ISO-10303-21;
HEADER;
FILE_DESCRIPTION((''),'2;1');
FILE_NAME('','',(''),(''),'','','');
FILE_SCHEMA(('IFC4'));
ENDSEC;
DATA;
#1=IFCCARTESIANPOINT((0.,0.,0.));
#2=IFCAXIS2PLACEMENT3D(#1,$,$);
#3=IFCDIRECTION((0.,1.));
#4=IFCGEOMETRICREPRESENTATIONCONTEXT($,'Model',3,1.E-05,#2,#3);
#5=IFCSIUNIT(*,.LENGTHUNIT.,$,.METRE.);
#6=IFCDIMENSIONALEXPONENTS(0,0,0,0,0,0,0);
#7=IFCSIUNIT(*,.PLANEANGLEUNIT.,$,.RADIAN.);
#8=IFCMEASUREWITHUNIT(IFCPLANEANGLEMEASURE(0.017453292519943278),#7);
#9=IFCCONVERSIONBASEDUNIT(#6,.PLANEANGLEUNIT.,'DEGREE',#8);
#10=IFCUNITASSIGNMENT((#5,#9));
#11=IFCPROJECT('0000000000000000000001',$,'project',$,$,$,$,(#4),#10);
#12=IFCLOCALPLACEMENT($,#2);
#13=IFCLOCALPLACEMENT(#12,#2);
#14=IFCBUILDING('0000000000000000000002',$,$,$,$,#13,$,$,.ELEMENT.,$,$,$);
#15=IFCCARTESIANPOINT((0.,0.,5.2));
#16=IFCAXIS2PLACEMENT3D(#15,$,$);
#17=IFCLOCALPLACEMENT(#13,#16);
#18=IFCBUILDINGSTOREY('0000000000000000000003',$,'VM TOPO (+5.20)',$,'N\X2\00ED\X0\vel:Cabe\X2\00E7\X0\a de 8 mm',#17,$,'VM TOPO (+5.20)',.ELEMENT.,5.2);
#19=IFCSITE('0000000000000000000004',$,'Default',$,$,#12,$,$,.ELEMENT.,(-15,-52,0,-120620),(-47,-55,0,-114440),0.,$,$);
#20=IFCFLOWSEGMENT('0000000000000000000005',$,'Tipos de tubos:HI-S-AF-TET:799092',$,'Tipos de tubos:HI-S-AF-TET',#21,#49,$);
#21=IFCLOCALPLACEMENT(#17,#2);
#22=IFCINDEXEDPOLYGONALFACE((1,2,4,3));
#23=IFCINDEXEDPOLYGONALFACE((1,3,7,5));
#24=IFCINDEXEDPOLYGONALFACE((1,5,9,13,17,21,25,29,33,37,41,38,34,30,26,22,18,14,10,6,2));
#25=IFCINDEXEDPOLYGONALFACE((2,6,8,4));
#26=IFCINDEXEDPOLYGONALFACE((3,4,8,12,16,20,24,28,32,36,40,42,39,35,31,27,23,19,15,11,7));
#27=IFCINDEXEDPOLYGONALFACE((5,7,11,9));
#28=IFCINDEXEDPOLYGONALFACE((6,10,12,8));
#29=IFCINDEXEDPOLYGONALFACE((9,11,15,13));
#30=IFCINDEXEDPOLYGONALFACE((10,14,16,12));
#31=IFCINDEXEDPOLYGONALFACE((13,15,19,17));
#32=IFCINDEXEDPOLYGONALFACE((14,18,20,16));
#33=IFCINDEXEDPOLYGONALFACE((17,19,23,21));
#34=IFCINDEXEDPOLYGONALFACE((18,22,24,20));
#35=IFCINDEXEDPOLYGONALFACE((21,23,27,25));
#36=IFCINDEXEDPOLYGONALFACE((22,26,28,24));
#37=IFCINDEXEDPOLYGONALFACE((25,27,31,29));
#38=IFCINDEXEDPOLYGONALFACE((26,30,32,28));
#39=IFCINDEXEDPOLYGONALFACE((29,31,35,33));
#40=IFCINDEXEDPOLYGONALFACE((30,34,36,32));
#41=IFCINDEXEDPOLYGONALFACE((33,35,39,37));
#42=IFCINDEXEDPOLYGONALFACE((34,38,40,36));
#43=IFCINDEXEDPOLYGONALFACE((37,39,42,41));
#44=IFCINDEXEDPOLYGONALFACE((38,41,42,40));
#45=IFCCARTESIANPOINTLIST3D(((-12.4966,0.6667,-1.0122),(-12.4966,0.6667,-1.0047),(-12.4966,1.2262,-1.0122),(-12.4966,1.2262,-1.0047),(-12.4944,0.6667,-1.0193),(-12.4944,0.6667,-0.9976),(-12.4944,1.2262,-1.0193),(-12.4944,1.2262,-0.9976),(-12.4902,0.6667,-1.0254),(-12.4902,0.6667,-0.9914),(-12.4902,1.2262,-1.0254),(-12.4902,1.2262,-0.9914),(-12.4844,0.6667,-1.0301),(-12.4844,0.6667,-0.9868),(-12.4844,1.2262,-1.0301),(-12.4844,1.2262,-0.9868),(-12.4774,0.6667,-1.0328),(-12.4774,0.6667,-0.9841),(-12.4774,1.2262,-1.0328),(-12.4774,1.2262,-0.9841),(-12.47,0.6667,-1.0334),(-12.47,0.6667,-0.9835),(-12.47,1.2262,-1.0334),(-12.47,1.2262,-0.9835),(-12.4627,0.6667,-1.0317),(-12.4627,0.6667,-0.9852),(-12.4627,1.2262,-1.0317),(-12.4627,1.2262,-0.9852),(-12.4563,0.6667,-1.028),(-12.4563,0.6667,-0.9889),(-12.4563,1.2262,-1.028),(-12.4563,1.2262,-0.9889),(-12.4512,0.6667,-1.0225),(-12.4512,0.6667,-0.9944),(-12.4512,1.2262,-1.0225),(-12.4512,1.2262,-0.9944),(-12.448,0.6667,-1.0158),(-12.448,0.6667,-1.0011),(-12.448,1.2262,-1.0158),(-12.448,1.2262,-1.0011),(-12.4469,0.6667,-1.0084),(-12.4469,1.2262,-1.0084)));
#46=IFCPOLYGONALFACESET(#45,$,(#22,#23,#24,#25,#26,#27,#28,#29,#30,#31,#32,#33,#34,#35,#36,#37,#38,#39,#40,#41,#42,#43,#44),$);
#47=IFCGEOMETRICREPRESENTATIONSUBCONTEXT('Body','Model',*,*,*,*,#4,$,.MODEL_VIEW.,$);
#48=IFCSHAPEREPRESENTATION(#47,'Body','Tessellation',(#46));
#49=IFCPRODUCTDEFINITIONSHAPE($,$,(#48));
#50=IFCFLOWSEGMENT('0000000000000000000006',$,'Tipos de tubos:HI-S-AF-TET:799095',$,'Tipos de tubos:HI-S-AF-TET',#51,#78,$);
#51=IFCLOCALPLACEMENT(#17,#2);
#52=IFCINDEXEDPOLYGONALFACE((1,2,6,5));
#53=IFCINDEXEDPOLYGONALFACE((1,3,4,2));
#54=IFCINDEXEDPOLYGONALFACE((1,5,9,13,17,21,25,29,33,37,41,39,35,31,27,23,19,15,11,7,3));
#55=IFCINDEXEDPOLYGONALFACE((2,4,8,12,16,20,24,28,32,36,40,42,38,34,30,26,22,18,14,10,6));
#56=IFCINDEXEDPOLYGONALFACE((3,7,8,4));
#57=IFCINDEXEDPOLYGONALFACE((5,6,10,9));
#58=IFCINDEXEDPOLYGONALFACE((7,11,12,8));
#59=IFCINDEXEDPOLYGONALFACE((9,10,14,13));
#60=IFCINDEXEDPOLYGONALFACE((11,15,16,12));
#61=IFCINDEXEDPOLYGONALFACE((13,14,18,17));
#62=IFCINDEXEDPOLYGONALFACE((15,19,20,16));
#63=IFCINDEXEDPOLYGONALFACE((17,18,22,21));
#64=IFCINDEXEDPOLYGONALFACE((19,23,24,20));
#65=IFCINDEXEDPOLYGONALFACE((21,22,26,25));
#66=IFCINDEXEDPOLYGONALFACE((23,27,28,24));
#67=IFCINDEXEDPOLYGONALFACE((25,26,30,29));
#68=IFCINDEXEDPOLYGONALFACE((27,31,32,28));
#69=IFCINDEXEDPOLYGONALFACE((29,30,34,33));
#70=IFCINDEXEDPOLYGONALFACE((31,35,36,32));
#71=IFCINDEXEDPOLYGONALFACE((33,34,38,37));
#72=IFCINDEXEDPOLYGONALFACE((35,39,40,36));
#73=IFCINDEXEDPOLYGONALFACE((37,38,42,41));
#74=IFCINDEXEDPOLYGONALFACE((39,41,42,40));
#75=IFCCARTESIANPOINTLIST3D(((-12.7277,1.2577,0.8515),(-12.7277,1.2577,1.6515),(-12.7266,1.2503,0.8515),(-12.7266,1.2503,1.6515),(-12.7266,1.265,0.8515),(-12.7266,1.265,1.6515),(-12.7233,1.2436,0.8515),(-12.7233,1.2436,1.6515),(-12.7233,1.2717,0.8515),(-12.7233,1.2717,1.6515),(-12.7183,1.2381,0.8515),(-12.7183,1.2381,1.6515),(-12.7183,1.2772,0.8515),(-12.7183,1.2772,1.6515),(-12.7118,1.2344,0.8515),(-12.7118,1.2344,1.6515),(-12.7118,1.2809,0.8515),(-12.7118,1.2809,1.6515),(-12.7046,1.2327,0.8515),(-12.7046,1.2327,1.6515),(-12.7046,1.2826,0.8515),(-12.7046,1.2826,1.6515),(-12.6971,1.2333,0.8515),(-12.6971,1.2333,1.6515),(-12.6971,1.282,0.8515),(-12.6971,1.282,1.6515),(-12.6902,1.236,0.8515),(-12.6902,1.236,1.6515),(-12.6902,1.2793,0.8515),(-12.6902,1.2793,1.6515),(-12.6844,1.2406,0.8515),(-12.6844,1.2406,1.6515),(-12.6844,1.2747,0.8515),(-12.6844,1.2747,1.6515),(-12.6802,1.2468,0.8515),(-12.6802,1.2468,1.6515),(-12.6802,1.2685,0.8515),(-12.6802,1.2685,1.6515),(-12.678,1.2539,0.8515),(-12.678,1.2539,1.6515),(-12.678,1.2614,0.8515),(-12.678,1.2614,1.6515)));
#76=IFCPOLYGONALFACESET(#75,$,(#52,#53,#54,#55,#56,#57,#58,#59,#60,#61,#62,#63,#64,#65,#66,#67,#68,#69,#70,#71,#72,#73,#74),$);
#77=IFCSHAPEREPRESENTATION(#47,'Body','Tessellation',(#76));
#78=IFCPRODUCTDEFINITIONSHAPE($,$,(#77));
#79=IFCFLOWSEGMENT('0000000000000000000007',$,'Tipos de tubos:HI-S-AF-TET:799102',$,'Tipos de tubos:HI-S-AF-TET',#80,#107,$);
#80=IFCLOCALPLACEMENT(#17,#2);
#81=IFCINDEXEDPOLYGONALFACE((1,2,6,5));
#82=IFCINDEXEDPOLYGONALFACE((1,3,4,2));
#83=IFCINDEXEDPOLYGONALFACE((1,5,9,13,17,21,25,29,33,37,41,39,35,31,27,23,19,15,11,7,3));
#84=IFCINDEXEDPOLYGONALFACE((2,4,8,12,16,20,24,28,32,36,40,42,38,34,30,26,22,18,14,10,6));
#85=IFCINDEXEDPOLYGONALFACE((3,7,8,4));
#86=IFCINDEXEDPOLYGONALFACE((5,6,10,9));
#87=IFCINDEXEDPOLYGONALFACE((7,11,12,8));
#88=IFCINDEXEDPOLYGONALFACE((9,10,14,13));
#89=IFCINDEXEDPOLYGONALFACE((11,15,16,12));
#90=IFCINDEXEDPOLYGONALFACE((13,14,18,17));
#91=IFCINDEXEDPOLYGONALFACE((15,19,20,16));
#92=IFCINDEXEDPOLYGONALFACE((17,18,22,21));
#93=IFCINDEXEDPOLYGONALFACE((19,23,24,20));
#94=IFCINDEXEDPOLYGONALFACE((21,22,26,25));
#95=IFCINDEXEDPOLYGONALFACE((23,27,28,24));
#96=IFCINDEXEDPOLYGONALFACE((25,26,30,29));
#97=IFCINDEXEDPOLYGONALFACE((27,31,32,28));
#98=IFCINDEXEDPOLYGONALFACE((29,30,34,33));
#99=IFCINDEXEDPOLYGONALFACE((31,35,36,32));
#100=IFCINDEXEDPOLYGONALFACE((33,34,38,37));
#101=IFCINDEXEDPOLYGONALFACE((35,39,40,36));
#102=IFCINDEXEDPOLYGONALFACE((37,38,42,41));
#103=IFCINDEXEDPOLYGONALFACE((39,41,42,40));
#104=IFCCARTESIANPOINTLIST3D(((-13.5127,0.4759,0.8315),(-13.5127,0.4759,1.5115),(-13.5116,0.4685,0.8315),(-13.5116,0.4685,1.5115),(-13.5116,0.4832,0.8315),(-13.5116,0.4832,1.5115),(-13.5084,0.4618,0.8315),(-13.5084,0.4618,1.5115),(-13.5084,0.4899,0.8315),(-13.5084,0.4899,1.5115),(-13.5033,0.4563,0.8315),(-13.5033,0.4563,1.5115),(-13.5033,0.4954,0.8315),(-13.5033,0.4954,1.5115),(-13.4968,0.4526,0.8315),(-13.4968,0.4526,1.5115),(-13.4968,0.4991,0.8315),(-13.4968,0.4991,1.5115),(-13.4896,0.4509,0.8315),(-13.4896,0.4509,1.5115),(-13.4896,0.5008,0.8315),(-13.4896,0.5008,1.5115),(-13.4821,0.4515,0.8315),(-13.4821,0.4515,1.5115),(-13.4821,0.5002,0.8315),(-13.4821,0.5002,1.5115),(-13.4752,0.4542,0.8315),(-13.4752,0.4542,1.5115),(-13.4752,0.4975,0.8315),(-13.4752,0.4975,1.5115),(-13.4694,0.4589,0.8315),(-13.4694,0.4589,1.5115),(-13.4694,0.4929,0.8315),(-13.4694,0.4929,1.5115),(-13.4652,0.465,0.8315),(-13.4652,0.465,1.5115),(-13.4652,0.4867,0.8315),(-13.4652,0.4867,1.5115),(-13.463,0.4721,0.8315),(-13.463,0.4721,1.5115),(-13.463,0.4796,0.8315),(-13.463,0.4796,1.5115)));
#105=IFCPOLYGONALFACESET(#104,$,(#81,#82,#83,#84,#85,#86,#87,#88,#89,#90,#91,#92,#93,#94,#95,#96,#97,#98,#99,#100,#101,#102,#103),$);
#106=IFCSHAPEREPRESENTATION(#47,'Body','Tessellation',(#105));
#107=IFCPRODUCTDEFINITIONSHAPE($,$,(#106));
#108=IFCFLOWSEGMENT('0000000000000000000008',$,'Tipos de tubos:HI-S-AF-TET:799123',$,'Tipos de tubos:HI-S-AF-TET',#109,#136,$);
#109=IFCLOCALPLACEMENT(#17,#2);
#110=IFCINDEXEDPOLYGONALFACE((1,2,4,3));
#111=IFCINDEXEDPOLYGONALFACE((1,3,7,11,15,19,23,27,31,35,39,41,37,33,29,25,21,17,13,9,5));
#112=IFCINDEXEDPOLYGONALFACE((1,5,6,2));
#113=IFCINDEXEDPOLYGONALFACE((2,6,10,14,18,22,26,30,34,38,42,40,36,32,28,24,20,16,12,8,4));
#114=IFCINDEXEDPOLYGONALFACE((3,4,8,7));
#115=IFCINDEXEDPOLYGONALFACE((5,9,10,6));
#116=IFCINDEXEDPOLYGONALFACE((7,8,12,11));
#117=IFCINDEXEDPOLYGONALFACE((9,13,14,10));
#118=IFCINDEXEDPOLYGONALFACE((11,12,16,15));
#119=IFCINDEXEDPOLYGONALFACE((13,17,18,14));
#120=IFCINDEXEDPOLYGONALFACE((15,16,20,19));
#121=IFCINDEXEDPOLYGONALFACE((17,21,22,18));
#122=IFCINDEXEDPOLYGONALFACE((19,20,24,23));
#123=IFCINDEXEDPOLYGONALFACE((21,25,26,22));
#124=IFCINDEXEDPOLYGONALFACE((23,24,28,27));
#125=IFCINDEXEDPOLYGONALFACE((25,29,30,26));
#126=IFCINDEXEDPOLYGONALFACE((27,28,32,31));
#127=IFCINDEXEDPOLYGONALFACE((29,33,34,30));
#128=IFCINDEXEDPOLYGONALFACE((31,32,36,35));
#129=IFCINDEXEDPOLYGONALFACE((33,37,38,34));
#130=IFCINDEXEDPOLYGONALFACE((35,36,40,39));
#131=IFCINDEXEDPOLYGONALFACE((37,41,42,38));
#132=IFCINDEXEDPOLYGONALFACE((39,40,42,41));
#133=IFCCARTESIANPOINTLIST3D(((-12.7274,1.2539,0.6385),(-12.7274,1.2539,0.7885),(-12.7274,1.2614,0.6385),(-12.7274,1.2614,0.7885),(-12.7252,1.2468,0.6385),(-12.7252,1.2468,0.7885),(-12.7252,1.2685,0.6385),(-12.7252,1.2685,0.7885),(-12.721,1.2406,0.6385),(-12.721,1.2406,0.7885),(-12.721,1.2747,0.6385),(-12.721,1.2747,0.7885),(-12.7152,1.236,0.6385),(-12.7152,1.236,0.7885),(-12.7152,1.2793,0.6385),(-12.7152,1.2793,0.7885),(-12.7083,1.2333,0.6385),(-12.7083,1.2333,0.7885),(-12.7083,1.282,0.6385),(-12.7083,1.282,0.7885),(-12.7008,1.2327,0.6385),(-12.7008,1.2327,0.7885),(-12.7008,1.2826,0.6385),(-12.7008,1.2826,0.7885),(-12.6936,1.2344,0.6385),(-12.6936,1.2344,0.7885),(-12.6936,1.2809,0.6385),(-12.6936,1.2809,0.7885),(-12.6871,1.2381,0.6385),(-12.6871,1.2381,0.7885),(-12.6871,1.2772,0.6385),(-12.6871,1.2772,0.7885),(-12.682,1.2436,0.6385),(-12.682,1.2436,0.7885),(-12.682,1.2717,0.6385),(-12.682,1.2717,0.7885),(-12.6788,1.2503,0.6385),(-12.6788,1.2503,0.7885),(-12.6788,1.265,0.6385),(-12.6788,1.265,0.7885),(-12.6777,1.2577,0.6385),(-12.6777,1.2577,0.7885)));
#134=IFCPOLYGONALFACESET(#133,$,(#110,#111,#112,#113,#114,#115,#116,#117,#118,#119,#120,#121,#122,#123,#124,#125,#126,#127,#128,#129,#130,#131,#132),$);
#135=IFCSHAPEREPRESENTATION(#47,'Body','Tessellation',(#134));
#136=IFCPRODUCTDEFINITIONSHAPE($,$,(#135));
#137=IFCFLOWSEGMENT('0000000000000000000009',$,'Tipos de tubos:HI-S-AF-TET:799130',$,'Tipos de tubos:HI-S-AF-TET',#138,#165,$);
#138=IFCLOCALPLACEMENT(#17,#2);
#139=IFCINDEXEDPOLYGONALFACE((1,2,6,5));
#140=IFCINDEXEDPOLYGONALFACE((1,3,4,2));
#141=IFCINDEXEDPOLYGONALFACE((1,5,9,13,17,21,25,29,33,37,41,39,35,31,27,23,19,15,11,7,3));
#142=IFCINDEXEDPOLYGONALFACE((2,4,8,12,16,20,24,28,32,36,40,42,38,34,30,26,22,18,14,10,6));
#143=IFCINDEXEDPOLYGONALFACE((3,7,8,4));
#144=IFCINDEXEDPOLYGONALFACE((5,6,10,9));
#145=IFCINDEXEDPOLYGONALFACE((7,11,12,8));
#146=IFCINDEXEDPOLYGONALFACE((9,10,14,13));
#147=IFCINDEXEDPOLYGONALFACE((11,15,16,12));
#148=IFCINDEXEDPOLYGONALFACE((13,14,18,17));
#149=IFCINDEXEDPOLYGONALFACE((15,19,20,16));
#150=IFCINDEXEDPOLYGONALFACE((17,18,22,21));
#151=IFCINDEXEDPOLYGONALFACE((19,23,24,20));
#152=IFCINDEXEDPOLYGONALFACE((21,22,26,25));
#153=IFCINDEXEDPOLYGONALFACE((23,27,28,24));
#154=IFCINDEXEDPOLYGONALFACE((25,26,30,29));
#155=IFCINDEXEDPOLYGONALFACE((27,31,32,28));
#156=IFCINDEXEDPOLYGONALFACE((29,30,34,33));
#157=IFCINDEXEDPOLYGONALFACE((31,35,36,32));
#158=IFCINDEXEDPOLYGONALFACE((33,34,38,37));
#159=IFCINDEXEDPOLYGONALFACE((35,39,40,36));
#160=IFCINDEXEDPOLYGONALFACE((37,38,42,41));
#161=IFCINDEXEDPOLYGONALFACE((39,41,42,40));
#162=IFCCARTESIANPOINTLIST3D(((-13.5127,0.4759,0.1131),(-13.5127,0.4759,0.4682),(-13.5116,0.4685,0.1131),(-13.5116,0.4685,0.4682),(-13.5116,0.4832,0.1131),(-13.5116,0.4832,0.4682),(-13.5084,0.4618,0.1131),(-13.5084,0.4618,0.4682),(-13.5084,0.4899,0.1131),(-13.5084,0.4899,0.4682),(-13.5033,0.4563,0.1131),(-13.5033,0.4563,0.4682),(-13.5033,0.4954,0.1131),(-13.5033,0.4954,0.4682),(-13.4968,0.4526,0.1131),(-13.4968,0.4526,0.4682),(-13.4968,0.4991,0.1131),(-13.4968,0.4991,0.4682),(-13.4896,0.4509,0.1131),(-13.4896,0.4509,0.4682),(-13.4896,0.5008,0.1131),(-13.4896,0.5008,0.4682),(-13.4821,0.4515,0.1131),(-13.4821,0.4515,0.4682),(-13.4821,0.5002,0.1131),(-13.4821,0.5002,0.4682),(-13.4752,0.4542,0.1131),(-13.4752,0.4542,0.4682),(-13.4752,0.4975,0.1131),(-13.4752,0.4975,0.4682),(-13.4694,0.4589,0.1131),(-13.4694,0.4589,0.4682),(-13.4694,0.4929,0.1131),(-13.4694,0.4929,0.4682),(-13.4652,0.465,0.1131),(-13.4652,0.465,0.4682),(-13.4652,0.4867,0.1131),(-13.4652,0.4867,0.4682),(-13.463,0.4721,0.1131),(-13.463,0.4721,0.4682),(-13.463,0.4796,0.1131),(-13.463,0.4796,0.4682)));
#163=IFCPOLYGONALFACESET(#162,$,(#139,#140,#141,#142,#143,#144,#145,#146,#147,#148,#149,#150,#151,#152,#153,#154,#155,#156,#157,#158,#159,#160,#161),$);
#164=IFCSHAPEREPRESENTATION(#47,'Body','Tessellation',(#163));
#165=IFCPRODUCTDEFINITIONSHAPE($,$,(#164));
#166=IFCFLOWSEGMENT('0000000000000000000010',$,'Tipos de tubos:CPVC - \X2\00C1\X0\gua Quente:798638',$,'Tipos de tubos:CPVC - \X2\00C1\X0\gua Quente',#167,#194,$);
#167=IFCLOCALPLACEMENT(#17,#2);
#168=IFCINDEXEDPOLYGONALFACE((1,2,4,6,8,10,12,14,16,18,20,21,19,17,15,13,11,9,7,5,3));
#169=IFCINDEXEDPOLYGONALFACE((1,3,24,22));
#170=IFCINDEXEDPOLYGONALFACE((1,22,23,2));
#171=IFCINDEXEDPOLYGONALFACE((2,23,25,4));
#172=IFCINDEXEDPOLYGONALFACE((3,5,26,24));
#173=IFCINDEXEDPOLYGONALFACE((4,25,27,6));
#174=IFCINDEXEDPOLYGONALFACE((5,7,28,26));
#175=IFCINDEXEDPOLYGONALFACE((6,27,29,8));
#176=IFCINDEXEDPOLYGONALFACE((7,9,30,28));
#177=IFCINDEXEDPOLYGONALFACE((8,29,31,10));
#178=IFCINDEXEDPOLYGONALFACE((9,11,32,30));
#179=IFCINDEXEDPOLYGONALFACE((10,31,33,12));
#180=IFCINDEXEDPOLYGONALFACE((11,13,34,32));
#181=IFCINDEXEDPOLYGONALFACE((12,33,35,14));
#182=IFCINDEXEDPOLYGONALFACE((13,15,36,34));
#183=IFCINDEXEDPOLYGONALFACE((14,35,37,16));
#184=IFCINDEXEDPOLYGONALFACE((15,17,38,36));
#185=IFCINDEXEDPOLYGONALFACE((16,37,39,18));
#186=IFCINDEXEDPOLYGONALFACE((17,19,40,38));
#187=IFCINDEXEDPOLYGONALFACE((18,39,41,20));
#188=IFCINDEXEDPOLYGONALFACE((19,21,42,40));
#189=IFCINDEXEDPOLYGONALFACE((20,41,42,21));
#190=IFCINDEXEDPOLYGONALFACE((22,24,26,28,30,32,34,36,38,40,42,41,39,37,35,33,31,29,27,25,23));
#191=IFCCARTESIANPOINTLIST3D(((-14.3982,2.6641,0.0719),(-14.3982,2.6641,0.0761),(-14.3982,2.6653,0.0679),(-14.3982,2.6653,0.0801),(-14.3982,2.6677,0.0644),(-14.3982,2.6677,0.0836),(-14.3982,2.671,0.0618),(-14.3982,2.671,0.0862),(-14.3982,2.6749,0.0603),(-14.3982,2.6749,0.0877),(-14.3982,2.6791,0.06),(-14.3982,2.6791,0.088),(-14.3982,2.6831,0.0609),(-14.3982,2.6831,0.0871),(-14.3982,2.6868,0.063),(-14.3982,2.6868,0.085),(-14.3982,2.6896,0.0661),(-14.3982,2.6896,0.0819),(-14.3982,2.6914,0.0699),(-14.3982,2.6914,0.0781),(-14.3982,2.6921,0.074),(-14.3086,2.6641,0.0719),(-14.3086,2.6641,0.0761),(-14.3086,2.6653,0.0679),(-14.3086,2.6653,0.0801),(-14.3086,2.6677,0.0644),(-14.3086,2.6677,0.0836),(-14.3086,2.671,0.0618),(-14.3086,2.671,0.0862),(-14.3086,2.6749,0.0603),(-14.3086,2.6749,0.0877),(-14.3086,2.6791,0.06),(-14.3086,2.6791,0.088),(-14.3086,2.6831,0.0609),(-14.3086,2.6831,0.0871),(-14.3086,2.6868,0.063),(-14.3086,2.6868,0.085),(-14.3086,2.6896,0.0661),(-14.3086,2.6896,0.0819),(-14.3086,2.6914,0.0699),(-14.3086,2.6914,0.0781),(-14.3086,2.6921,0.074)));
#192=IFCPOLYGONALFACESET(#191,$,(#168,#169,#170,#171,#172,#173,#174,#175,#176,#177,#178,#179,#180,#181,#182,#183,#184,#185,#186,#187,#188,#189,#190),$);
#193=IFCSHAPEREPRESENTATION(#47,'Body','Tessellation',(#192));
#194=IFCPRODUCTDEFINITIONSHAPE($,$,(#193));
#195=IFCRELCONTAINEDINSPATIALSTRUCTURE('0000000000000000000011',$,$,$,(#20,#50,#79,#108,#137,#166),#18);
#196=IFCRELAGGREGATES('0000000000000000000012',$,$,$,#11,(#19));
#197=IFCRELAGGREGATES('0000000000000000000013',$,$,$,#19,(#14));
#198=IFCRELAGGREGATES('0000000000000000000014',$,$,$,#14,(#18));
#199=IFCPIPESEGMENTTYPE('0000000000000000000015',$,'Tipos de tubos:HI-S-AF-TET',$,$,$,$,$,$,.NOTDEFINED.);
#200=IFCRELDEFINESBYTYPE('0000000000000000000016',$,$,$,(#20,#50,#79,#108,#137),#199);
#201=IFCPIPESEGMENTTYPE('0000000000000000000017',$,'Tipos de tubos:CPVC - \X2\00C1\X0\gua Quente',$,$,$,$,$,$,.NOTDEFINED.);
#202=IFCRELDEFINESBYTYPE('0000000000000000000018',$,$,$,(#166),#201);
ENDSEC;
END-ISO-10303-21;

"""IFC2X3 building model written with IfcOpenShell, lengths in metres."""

from ifc_helpers import new_model, entity, si_unit, converted_unit, direction, frame, origin, origin_2d_with_axis, place, context, subcontext, project, spatial, circle, extrude, type_object, element, save


model = new_model("IFC2X3")

# Units and contexts
model_context = context("Model", 3, precision=1e-05, world=origin(), true_north=direction((0.0, 1.0)))
body_context = subcontext(model_context, "Body", "Model", "MODEL_VIEW")
ifc_project = project(units=[si_unit("LENGTHUNIT", "METRE"), converted_unit("PLANEANGLEUNIT", "DEGREE", entity("IfcPlaneAngleMeasure", 0.017453292519943278), si_unit("PLANEANGLEUNIT", "RADIAN"), dimensions=[0, 0, 0, 0, 0, 0, 0])], contexts=[model_context])

# Site, building, storey
site_placement = place(None, origin())
site = spatial("IfcSite", under=ifc_project, at=site_placement, Name="Default", CompositionType="ELEMENT", RefLatitude=(-15, -52, 0, -120620), RefLongitude=(-47, -55, 0, -114440), RefElevation=0.0)
building_placement = place(site_placement, origin())
building = spatial("IfcBuilding", under=site, at=building_placement, CompositionType="ELEMENT")
storey_placement = place(building_placement, frame((0.0, 0.0, 5.2)))
storey = spatial("IfcBuildingStorey", under=building, at=storey_placement, Name="VM TOPO (+5.20)", ObjectType="Nível:Cabeça de 8 mm", LongName="VM TOPO (+5.20)", CompositionType="ELEMENT", Elevation=5.2)

# Flow segments
pipe_segment_type_1 = type_object("IfcPipeSegmentType", Name="Tipos de tubos:HI-S-AF-TET", PredefinedType="NOTDEFINED")
flow_segment_1_placement = place(storey_placement, origin())
element("IfcFlowSegment", 1, at=flow_segment_1_placement, inside=storey, type_object=pipe_segment_type_1, Name="Tipos de tubos:HI-S-AF-TET:799092", ObjectType="Tipos de tubos:HI-S-AF-TET", context=body_context, shape_type="SweptSolid", body=[
    extrude(circle(Radius=0.025, at=origin_2d_with_axis()), frame((-12.4719, 0.6667, -1.0084), z_axis=(0.0, 1.0, 0.0), x_axis=(1.0, 0.0, 0.0)), (0.0, 0.0, 1.0), 0.5595),
])
flow_segment_2_placement = place(storey_placement, origin())
element("IfcFlowSegment", 2, at=flow_segment_2_placement, inside=storey, type_object=pipe_segment_type_1, Name="Tipos de tubos:HI-S-AF-TET:799095", ObjectType="Tipos de tubos:HI-S-AF-TET", context=body_context, shape_type="SweptSolid", body=[
    extrude(circle(Radius=0.025, at=origin_2d_with_axis()), frame((-12.7027, 1.2577, 0.8515), z_axis=(0.0, 0.0, 1.0), x_axis=(-1.0, 0.0, 0.0)), (0.0, 0.0, 1.0), 0.8),
])
flow_segment_3_placement = place(storey_placement, origin())
element("IfcFlowSegment", 3, at=flow_segment_3_placement, inside=storey, type_object=pipe_segment_type_1, Name="Tipos de tubos:HI-S-AF-TET:799102", ObjectType="Tipos de tubos:HI-S-AF-TET", context=body_context, shape_type="SweptSolid", body=[
    extrude(circle(Radius=0.025, at=origin_2d_with_axis()), frame((-13.4877, 0.4759, 0.8315), z_axis=(0.0, 0.0, 1.0), x_axis=(-1.0, 0.0, 0.0)), (0.0, 0.0, 1.0), 0.68),
])
flow_segment_4_placement = place(storey_placement, origin())
element("IfcFlowSegment", 4, at=flow_segment_4_placement, inside=storey, type_object=pipe_segment_type_1, Name="Tipos de tubos:HI-S-AF-TET:799123", ObjectType="Tipos de tubos:HI-S-AF-TET", context=body_context, shape_type="SweptSolid", body=[
    extrude(circle(Radius=0.025, at=origin_2d_with_axis()), frame((-12.7027, 1.2577, 0.6385)), (0.0, 0.0, 1.0), 0.15),
])
flow_segment_5_placement = place(storey_placement, origin())
element("IfcFlowSegment", 5, at=flow_segment_5_placement, inside=storey, type_object=pipe_segment_type_1, Name="Tipos de tubos:HI-S-AF-TET:799130", ObjectType="Tipos de tubos:HI-S-AF-TET", context=body_context, shape_type="SweptSolid", body=[
    extrude(circle(Radius=0.025, at=origin_2d_with_axis()), frame((-13.4877, 0.4759, 0.1131), z_axis=(0.0, 0.0, 1.0), x_axis=(-1.0, 0.0, 0.0)), (0.0, 0.0, 1.0), 0.3551),
])
pipe_segment_type_2 = type_object("IfcPipeSegmentType", Name="Tipos de tubos:CPVC - Água Quente", PredefinedType="NOTDEFINED")
flow_segment_6_placement = place(storey_placement, origin())
element("IfcFlowSegment", 6, at=flow_segment_6_placement, inside=storey, type_object=pipe_segment_type_2, Name="Tipos de tubos:CPVC - Água Quente:798638", ObjectType="Tipos de tubos:CPVC - Água Quente", context=body_context, shape_type="SweptSolid", body=[
    extrude(circle(Radius=0.0141, at=origin_2d_with_axis()), frame((-14.3982, 2.678, 0.074), z_axis=(1.0, 0.0, 0.0), x_axis=(0.0, 1.0, 0.0)), (0.0, 0.0, 1.0), 0.0896),
])

save(model, "model.ifc")
